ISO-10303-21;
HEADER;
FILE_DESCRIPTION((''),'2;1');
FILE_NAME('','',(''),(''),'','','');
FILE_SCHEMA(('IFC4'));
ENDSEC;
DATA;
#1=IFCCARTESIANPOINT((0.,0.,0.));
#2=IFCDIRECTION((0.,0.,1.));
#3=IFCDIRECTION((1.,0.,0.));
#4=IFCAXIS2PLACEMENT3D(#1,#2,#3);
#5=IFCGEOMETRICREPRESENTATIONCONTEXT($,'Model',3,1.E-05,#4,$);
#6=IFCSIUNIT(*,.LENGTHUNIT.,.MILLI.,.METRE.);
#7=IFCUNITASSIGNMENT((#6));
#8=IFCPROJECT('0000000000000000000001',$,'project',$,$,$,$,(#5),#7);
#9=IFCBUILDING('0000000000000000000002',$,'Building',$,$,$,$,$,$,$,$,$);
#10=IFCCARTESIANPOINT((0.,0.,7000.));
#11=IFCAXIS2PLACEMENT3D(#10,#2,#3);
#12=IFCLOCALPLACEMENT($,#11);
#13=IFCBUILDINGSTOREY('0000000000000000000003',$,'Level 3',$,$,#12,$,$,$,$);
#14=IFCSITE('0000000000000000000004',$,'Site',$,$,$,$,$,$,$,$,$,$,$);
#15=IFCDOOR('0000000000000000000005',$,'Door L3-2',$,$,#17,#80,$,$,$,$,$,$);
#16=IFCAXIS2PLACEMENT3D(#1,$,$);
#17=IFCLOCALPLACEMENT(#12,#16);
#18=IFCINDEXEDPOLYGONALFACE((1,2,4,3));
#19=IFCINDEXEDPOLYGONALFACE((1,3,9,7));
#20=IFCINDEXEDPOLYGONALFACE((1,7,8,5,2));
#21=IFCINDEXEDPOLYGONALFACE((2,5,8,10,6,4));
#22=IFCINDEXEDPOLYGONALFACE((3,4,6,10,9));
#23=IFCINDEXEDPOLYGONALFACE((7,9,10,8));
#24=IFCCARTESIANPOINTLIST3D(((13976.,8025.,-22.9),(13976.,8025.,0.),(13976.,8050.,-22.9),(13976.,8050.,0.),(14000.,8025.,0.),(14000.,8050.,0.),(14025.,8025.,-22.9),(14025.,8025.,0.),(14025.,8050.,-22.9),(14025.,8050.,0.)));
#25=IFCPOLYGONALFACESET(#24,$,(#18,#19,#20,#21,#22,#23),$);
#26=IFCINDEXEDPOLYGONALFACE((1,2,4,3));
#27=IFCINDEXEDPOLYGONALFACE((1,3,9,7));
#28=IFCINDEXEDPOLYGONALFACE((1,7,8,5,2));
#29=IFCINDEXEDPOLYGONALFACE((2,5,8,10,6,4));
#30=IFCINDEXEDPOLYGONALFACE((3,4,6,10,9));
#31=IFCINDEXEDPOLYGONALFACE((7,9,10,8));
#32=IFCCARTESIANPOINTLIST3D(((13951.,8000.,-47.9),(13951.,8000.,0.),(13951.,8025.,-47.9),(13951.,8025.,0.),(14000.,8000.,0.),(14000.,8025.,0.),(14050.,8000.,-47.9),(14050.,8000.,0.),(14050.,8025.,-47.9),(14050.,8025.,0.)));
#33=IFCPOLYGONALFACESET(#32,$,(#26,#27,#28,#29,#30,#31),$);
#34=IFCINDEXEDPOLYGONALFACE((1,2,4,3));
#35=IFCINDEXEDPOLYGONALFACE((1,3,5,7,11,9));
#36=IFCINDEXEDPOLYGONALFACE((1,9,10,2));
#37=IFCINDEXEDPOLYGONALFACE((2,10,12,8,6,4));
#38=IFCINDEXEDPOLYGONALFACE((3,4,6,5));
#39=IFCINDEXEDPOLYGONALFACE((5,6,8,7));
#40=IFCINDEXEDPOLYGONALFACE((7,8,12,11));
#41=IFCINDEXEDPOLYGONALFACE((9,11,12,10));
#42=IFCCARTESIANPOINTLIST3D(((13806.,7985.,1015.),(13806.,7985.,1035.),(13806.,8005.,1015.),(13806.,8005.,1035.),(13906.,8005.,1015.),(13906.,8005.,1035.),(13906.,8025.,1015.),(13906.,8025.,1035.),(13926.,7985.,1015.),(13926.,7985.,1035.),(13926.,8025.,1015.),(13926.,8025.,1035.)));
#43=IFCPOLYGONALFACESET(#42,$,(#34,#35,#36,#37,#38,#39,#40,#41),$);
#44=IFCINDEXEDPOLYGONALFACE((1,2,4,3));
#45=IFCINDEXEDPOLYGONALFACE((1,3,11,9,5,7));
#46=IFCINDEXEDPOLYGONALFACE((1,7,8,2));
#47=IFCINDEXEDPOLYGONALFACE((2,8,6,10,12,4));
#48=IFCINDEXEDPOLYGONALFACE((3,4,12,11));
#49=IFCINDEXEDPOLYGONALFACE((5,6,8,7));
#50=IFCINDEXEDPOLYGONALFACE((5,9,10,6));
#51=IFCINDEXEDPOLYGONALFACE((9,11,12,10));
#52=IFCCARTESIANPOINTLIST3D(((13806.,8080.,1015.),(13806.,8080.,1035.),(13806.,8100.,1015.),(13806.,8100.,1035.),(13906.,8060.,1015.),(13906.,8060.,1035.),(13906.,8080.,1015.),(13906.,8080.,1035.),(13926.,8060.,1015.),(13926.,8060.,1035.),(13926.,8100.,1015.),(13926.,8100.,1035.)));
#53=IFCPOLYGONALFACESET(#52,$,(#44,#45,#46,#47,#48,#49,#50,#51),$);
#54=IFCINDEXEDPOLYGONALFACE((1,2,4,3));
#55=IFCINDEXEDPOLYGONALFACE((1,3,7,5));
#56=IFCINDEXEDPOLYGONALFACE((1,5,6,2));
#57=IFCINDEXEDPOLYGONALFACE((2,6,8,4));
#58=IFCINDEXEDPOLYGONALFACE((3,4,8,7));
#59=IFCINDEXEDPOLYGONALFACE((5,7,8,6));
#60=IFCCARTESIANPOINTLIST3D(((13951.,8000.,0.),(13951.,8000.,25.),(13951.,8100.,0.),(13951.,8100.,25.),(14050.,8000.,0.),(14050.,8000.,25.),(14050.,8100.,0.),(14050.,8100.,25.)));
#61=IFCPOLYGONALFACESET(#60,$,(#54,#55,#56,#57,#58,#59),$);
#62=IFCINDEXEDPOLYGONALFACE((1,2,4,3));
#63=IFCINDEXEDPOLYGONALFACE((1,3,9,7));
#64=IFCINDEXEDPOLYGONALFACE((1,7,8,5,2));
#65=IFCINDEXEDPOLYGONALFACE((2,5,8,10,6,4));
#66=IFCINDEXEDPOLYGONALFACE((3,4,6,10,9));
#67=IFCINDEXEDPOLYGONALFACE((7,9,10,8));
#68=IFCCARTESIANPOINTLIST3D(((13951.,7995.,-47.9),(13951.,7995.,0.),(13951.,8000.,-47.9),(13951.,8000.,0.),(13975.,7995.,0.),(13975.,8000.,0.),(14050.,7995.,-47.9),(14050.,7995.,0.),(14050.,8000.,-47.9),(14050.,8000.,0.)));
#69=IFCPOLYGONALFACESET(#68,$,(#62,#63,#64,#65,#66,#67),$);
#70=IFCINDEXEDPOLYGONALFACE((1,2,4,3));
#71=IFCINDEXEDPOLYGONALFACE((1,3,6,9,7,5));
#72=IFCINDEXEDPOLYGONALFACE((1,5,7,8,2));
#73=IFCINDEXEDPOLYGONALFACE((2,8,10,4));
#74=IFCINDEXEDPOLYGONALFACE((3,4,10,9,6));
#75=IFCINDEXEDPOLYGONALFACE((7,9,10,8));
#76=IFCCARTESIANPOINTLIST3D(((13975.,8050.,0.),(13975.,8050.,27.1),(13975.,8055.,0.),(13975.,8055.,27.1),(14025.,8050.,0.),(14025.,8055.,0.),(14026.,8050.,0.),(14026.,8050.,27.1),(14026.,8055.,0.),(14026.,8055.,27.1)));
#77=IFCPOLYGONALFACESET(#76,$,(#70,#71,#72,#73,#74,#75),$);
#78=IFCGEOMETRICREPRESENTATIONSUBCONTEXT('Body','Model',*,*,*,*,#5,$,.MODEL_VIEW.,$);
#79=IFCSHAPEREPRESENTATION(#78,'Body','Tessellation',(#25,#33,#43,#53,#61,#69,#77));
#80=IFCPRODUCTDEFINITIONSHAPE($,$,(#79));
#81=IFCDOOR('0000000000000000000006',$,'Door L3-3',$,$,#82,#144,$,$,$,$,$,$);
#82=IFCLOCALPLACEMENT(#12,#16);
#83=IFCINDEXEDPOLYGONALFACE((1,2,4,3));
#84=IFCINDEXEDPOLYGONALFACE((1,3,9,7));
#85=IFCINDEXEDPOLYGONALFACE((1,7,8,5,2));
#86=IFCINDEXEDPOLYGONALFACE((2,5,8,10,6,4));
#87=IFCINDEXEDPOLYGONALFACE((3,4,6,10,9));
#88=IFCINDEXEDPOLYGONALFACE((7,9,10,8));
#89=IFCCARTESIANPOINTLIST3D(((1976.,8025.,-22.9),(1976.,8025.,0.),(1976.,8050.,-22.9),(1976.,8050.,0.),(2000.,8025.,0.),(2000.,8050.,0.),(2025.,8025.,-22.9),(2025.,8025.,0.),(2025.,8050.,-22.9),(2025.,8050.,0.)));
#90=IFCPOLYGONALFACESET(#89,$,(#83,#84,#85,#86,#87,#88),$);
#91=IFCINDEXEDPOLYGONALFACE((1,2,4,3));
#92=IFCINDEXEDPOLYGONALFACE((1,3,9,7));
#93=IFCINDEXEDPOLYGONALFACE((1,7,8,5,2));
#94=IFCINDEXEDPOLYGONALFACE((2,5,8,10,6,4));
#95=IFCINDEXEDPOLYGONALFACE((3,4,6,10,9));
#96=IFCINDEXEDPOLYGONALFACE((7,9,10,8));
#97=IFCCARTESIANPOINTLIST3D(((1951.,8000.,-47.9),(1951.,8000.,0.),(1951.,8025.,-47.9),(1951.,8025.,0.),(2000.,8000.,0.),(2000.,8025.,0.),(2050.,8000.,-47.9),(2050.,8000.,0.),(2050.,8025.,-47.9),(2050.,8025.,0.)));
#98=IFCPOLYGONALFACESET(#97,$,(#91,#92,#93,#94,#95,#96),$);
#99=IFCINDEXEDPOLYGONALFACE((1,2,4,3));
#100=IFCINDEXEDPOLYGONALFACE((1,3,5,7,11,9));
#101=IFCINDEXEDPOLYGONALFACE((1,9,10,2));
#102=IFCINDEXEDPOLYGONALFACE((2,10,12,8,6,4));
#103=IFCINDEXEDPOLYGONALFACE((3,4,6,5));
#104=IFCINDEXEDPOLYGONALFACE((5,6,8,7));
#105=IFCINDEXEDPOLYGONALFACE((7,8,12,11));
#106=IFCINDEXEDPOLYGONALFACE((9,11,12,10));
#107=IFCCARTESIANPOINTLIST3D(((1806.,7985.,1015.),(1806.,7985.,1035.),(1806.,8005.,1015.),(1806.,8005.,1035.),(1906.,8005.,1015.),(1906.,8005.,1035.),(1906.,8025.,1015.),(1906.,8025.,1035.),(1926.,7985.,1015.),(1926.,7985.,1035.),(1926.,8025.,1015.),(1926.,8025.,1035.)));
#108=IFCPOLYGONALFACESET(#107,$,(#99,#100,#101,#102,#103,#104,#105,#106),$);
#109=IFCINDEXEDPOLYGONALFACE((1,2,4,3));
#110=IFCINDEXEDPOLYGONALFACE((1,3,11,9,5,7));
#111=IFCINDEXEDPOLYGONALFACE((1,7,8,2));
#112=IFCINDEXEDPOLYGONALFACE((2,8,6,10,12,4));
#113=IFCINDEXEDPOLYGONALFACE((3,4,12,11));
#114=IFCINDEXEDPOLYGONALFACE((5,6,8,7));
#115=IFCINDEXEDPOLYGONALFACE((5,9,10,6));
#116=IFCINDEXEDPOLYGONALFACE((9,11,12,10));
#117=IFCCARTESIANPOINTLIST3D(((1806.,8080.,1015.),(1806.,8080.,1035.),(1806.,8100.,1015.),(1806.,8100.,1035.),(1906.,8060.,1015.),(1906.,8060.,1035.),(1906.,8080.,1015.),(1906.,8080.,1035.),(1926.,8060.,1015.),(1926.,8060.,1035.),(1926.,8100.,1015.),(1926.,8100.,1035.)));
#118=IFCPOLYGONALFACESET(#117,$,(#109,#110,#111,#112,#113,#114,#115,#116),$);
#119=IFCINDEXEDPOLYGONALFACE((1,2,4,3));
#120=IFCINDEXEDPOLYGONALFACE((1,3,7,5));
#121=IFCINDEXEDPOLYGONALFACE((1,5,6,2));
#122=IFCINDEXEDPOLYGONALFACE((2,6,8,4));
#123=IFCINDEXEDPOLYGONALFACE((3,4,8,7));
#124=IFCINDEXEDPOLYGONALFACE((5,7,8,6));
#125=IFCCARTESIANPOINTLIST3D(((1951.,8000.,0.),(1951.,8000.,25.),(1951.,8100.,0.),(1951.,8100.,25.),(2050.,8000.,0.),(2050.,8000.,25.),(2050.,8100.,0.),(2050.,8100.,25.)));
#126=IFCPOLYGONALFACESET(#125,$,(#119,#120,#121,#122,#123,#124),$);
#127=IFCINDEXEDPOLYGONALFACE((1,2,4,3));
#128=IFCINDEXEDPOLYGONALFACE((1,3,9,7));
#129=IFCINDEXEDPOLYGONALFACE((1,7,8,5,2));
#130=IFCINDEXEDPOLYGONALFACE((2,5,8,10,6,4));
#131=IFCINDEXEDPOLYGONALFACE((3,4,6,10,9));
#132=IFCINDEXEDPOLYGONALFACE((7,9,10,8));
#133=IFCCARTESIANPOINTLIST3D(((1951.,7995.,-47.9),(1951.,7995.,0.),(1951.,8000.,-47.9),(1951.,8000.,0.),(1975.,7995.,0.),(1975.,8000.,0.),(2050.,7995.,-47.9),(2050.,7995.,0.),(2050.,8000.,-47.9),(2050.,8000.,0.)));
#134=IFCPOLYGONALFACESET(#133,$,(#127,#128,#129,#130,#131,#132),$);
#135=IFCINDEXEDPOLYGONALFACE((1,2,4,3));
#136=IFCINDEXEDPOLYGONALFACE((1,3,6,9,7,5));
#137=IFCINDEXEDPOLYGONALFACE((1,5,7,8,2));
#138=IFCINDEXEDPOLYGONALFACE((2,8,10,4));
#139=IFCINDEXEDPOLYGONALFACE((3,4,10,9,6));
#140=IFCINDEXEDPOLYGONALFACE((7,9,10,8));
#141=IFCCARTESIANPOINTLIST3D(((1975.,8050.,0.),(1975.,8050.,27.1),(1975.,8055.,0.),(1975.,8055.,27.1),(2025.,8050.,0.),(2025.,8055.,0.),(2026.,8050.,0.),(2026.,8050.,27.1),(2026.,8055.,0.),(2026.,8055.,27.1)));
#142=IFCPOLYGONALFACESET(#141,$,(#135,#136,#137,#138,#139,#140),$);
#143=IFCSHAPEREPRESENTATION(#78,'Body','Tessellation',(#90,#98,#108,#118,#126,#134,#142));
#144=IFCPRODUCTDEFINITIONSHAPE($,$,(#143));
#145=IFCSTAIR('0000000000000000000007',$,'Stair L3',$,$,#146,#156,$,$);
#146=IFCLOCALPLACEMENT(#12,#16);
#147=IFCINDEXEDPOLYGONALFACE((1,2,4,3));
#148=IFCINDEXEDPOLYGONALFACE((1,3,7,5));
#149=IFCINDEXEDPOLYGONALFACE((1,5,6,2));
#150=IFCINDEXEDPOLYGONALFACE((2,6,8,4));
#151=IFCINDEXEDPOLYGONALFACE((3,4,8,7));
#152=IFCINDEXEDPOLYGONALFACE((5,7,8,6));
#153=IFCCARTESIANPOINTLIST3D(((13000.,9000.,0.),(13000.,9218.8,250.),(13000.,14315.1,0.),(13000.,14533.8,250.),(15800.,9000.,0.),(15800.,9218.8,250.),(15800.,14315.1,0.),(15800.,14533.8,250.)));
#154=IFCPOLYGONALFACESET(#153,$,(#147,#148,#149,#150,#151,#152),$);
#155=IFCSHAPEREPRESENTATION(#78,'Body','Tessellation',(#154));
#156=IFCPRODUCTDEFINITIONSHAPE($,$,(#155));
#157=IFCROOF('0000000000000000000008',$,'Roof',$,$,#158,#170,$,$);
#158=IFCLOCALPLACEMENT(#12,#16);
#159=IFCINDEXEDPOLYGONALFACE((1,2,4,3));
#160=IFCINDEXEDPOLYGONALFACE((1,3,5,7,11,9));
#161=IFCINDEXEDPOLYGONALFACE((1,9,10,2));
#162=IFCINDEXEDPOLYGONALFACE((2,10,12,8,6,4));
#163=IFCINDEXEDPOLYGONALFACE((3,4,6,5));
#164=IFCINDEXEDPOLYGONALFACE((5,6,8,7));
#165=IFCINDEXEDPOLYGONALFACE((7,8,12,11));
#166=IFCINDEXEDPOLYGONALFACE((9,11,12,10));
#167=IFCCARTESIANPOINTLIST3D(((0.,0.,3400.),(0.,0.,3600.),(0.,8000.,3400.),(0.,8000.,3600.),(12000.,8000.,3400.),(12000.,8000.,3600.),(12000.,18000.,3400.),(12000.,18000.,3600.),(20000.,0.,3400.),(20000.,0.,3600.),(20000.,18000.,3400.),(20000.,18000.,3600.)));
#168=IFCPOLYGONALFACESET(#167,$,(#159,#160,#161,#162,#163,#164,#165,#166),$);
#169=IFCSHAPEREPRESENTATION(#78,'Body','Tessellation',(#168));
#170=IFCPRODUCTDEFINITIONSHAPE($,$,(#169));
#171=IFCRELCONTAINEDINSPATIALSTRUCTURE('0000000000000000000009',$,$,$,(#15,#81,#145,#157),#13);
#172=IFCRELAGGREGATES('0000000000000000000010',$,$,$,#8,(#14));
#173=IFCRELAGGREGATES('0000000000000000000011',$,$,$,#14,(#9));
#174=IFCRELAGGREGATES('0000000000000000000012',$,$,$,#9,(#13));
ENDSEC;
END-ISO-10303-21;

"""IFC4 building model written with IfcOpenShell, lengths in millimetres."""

from ifc_helpers import new_model, si_unit, frame, origin_with_axes, place, context, subcontext, project, spatial, line, indexed_curve, outline, extrude, element, save


model = new_model("IFC4")

# Units and contexts
model_context = context("Model", 3, precision=1e-05, world=origin_with_axes())
body_context = subcontext(model_context, "Body", "Model", "MODEL_VIEW")
ifc_project = project(units=[si_unit("LENGTHUNIT", "METRE", prefix="MILLI")], contexts=[model_context])

# Site, building, storey
site = spatial("IfcSite", under=ifc_project, Name="Site")
building = spatial("IfcBuilding", under=site, Name="Building")
storey_placement = place(None, frame((0.0, 0.0, 7000.0), z_axis=(0.0, 0.0, 1.0), x_axis=(1.0, 0.0, 0.0)))
storey = spatial("IfcBuildingStorey", under=building, at=storey_placement, Name="Level 3")

# Doors
door_1_placement = place(storey_placement, frame((14000.0, 8000.0, 0.0), z_axis=(0.0, 0.0, 1.0), x_axis=(1.0, 0.0, 0.0)))
element("IfcDoor", 1, at=door_1_placement, inside=storey, Name="Door L3-2", context=body_context, shape_type="SweptSolid", body=[
    extrude(outline(indexed_curve([(0.0, 0.0), (0.0, 2.1), (1.0, 2.1), (1.0, 0.0), (-24.0, 0.0), (-24.0, -22.9), (25.0, -22.9), (25.0, 0.0)], segments=[line(1, 2, 3, 4, 5, 6, 7, 8, 1)])), frame((0.0, 25.0, 0.0), z_axis=(0.0, -1.0, 0.0), x_axis=(1.0, 0.0, 0.0)), (0.0, 0.0, -1.0), 25.0),
    extrude(outline(indexed_curve([(0.0, 0.0), (0.0, 2.1), (1.0, 2.1), (1.0, 0.0), (-49.0, 0.0), (-49.0, -47.9), (50.0, -47.9), (50.0, 0.0)], segments=[line(1, 2, 3, 4, 5, 6, 7, 8, 1)])), frame((0.0, 0.0, 0.0), z_axis=(0.0, -1.0, 0.0), x_axis=(1.0, 0.0, 0.0)), (0.0, 0.0, -1.0), 25.0),
    extrude(outline(indexed_curve([(0.0, 0.0), (-49.0, 0.0), (-49.0, 35.0), (0.0, 35.0)], segments=[line(1, 2, 3, 4, 1)])), frame((25.0, 25.0, 25.0), z_axis=(0.0, 0.0, 1.0), x_axis=(1.0, 0.0, 0.0)), (0.0, 0.0, 1.0), -47.9),
    extrude(outline(indexed_curve([(0.0, 0.0), (0.0, -40.0), (-120.0, -40.0), (-120.0, -20.0), (-20.0, -20.0), (-20.0, 0.0)], segments=[line(1, 2, 3, 4, 5, 6, 1)])), frame((-74.0, 25.0, 1015.0), z_axis=(0.0, 0.0, 1.0), x_axis=(1.0, 0.0, 0.0)), (0.0, 0.0, 1.0), 20.0),
    extrude(outline(indexed_curve([(0.0, 0.0), (0.0, 40.0), (-120.0, 40.0), (-120.0, 20.0), (-20.0, 20.0), (-20.0, 0.0)], segments=[line(1, 2, 3, 4, 5, 6, 1)])), frame((-74.0, 60.0, 1015.0), z_axis=(0.0, 0.0, 1.0), x_axis=(1.0, 0.0, 0.0)), (0.0, 0.0, 1.0), 20.0),
    extrude(outline(indexed_curve([(0.0, 0.0), (-99.0, 0.0), (-99.0, 100.0), (0.0, 100.0)], segments=[line(1, 2, 3, 4, 1)])), frame((50.0, 0.0, 0.0), z_axis=(0.0, 0.0, 1.0), x_axis=(1.0, 0.0, 0.0)), (0.0, 0.0, 1.0), 25.0),
    extrude(outline(indexed_curve([(0.0, 0.0), (0.0, 27.1), (51.0, 27.1), (51.0, 0.0), (-24.0, 0.0), (-24.0, -47.9), (75.0, -47.9), (75.0, 0.0)], segments=[line(1, 2, 3, 4, 5, 6, 7, 8, 1)])), frame((-25.0, -5.0, 0.0), z_axis=(0.0, -1.0, 0.0), x_axis=(1.0, 0.0, 0.0)), (0.0, 0.0, -1.0), 5.0),
    extrude(outline(indexed_curve([(0.0, 0.0), (0.0, 27.1), (51.0, 27.1), (51.0, 0.0), (1.0, 0.0), (1.0, -22.9), (50.0, -22.9), (50.0, 0.0)], segments=[line(1, 2, 3, 4, 5, 6, 7, 8, 1)])), frame((-25.0, 50.0, 0.0), z_axis=(0.0, -1.0, 0.0), x_axis=(1.0, 0.0, 0.0)), (0.0, 0.0, -1.0), 5.0),
])
door_2_placement = place(storey_placement, frame((2000.0, 8000.0, 0.0), z_axis=(0.0, 0.0, 1.0), x_axis=(1.0, 0.0, 0.0)))
element("IfcDoor", 2, at=door_2_placement, inside=storey, Name="Door L3-3", context=body_context, shape_type="SweptSolid", body=[
    extrude(outline(indexed_curve([(0.0, 0.0), (0.0, 2.1), (1.0, 2.1), (1.0, 0.0), (-24.0, 0.0), (-24.0, -22.9), (25.0, -22.9), (25.0, 0.0)], segments=[line(1, 2, 3, 4, 5, 6, 7, 8, 1)])), frame((0.0, 25.0, 0.0), z_axis=(0.0, -1.0, 0.0), x_axis=(1.0, 0.0, 0.0)), (0.0, 0.0, -1.0), 25.0),
    extrude(outline(indexed_curve([(0.0, 0.0), (0.0, 2.1), (1.0, 2.1), (1.0, 0.0), (-49.0, 0.0), (-49.0, -47.9), (50.0, -47.9), (50.0, 0.0)], segments=[line(1, 2, 3, 4, 5, 6, 7, 8, 1)])), frame((0.0, 0.0, 0.0), z_axis=(0.0, -1.0, 0.0), x_axis=(1.0, 0.0, 0.0)), (0.0, 0.0, -1.0), 25.0),
    extrude(outline(indexed_curve([(0.0, 0.0), (-49.0, 0.0), (-49.0, 35.0), (0.0, 35.0)], segments=[line(1, 2, 3, 4, 1)])), frame((25.0, 25.0, 25.0), z_axis=(0.0, 0.0, 1.0), x_axis=(1.0, 0.0, 0.0)), (0.0, 0.0, 1.0), -47.9),
    extrude(outline(indexed_curve([(0.0, 0.0), (0.0, -40.0), (-120.0, -40.0), (-120.0, -20.0), (-20.0, -20.0), (-20.0, 0.0)], segments=[line(1, 2, 3, 4, 5, 6, 1)])), frame((-74.0, 25.0, 1015.0), z_axis=(0.0, 0.0, 1.0), x_axis=(1.0, 0.0, 0.0)), (0.0, 0.0, 1.0), 20.0),
    extrude(outline(indexed_curve([(0.0, 0.0), (0.0, 40.0), (-120.0, 40.0), (-120.0, 20.0), (-20.0, 20.0), (-20.0, 0.0)], segments=[line(1, 2, 3, 4, 5, 6, 1)])), frame((-74.0, 60.0, 1015.0), z_axis=(0.0, 0.0, 1.0), x_axis=(1.0, 0.0, 0.0)), (0.0, 0.0, 1.0), 20.0),
    extrude(outline(indexed_curve([(0.0, 0.0), (-99.0, 0.0), (-99.0, 100.0), (0.0, 100.0)], segments=[line(1, 2, 3, 4, 1)])), frame((50.0, 0.0, 0.0), z_axis=(0.0, 0.0, 1.0), x_axis=(1.0, 0.0, 0.0)), (0.0, 0.0, 1.0), 25.0),
    extrude(outline(indexed_curve([(0.0, 0.0), (0.0, 27.1), (51.0, 27.1), (51.0, 0.0), (-24.0, 0.0), (-24.0, -47.9), (75.0, -47.9), (75.0, 0.0)], segments=[line(1, 2, 3, 4, 5, 6, 7, 8, 1)])), frame((-25.0, -5.0, 0.0), z_axis=(0.0, -1.0, 0.0), x_axis=(1.0, 0.0, 0.0)), (0.0, 0.0, -1.0), 5.0),
    extrude(outline(indexed_curve([(0.0, 0.0), (0.0, 27.1), (51.0, 27.1), (51.0, 0.0), (1.0, 0.0), (1.0, -22.9), (50.0, -22.9), (50.0, 0.0)], segments=[line(1, 2, 3, 4, 5, 6, 7, 8, 1)])), frame((-25.0, 50.0, 0.0), z_axis=(0.0, -1.0, 0.0), x_axis=(1.0, 0.0, 0.0)), (0.0, 0.0, -1.0), 5.0),
])

# Stair
stair_placement = place(storey_placement, frame((13000.0, 9000.0, 0.0), z_axis=(0.0, 0.0, 1.0), x_axis=(1.0, 0.0, 0.0)))
element("IfcStair", 3, at=stair_placement, inside=storey, Name="Stair L3", context=body_context, shape_type="SweptSolid", body=[
    extrude(outline(indexed_curve([(0.0, 0.0), (2800.0, 0.0), (2800.0, 5315.1), (0.0, 5315.1), (0.0, 0.0)])), None, (0.0, 0.658505, 0.752577), 332.2),
])

# Roof
roof_placement = place(storey_placement, frame((0.0, 0.0, 3400.0), z_axis=(0.0, 0.0, 1.0), x_axis=(1.0, 0.0, 0.0)))
element("IfcRoof", 4, at=roof_placement, inside=storey, Name="Roof", context=body_context, shape_type="SweptSolid", body=[
    extrude(outline(indexed_curve([(0.0, 0.0), (20000.0, 0.0), (20000.0, 18000.0), (12000.0, 18000.0), (12000.0, 8000.0), (0.0, 8000.0), (0.0, 0.0)])), None, (0.0, 0.0, 1.0), 200.0),
])

save(model, "model.ifc")
